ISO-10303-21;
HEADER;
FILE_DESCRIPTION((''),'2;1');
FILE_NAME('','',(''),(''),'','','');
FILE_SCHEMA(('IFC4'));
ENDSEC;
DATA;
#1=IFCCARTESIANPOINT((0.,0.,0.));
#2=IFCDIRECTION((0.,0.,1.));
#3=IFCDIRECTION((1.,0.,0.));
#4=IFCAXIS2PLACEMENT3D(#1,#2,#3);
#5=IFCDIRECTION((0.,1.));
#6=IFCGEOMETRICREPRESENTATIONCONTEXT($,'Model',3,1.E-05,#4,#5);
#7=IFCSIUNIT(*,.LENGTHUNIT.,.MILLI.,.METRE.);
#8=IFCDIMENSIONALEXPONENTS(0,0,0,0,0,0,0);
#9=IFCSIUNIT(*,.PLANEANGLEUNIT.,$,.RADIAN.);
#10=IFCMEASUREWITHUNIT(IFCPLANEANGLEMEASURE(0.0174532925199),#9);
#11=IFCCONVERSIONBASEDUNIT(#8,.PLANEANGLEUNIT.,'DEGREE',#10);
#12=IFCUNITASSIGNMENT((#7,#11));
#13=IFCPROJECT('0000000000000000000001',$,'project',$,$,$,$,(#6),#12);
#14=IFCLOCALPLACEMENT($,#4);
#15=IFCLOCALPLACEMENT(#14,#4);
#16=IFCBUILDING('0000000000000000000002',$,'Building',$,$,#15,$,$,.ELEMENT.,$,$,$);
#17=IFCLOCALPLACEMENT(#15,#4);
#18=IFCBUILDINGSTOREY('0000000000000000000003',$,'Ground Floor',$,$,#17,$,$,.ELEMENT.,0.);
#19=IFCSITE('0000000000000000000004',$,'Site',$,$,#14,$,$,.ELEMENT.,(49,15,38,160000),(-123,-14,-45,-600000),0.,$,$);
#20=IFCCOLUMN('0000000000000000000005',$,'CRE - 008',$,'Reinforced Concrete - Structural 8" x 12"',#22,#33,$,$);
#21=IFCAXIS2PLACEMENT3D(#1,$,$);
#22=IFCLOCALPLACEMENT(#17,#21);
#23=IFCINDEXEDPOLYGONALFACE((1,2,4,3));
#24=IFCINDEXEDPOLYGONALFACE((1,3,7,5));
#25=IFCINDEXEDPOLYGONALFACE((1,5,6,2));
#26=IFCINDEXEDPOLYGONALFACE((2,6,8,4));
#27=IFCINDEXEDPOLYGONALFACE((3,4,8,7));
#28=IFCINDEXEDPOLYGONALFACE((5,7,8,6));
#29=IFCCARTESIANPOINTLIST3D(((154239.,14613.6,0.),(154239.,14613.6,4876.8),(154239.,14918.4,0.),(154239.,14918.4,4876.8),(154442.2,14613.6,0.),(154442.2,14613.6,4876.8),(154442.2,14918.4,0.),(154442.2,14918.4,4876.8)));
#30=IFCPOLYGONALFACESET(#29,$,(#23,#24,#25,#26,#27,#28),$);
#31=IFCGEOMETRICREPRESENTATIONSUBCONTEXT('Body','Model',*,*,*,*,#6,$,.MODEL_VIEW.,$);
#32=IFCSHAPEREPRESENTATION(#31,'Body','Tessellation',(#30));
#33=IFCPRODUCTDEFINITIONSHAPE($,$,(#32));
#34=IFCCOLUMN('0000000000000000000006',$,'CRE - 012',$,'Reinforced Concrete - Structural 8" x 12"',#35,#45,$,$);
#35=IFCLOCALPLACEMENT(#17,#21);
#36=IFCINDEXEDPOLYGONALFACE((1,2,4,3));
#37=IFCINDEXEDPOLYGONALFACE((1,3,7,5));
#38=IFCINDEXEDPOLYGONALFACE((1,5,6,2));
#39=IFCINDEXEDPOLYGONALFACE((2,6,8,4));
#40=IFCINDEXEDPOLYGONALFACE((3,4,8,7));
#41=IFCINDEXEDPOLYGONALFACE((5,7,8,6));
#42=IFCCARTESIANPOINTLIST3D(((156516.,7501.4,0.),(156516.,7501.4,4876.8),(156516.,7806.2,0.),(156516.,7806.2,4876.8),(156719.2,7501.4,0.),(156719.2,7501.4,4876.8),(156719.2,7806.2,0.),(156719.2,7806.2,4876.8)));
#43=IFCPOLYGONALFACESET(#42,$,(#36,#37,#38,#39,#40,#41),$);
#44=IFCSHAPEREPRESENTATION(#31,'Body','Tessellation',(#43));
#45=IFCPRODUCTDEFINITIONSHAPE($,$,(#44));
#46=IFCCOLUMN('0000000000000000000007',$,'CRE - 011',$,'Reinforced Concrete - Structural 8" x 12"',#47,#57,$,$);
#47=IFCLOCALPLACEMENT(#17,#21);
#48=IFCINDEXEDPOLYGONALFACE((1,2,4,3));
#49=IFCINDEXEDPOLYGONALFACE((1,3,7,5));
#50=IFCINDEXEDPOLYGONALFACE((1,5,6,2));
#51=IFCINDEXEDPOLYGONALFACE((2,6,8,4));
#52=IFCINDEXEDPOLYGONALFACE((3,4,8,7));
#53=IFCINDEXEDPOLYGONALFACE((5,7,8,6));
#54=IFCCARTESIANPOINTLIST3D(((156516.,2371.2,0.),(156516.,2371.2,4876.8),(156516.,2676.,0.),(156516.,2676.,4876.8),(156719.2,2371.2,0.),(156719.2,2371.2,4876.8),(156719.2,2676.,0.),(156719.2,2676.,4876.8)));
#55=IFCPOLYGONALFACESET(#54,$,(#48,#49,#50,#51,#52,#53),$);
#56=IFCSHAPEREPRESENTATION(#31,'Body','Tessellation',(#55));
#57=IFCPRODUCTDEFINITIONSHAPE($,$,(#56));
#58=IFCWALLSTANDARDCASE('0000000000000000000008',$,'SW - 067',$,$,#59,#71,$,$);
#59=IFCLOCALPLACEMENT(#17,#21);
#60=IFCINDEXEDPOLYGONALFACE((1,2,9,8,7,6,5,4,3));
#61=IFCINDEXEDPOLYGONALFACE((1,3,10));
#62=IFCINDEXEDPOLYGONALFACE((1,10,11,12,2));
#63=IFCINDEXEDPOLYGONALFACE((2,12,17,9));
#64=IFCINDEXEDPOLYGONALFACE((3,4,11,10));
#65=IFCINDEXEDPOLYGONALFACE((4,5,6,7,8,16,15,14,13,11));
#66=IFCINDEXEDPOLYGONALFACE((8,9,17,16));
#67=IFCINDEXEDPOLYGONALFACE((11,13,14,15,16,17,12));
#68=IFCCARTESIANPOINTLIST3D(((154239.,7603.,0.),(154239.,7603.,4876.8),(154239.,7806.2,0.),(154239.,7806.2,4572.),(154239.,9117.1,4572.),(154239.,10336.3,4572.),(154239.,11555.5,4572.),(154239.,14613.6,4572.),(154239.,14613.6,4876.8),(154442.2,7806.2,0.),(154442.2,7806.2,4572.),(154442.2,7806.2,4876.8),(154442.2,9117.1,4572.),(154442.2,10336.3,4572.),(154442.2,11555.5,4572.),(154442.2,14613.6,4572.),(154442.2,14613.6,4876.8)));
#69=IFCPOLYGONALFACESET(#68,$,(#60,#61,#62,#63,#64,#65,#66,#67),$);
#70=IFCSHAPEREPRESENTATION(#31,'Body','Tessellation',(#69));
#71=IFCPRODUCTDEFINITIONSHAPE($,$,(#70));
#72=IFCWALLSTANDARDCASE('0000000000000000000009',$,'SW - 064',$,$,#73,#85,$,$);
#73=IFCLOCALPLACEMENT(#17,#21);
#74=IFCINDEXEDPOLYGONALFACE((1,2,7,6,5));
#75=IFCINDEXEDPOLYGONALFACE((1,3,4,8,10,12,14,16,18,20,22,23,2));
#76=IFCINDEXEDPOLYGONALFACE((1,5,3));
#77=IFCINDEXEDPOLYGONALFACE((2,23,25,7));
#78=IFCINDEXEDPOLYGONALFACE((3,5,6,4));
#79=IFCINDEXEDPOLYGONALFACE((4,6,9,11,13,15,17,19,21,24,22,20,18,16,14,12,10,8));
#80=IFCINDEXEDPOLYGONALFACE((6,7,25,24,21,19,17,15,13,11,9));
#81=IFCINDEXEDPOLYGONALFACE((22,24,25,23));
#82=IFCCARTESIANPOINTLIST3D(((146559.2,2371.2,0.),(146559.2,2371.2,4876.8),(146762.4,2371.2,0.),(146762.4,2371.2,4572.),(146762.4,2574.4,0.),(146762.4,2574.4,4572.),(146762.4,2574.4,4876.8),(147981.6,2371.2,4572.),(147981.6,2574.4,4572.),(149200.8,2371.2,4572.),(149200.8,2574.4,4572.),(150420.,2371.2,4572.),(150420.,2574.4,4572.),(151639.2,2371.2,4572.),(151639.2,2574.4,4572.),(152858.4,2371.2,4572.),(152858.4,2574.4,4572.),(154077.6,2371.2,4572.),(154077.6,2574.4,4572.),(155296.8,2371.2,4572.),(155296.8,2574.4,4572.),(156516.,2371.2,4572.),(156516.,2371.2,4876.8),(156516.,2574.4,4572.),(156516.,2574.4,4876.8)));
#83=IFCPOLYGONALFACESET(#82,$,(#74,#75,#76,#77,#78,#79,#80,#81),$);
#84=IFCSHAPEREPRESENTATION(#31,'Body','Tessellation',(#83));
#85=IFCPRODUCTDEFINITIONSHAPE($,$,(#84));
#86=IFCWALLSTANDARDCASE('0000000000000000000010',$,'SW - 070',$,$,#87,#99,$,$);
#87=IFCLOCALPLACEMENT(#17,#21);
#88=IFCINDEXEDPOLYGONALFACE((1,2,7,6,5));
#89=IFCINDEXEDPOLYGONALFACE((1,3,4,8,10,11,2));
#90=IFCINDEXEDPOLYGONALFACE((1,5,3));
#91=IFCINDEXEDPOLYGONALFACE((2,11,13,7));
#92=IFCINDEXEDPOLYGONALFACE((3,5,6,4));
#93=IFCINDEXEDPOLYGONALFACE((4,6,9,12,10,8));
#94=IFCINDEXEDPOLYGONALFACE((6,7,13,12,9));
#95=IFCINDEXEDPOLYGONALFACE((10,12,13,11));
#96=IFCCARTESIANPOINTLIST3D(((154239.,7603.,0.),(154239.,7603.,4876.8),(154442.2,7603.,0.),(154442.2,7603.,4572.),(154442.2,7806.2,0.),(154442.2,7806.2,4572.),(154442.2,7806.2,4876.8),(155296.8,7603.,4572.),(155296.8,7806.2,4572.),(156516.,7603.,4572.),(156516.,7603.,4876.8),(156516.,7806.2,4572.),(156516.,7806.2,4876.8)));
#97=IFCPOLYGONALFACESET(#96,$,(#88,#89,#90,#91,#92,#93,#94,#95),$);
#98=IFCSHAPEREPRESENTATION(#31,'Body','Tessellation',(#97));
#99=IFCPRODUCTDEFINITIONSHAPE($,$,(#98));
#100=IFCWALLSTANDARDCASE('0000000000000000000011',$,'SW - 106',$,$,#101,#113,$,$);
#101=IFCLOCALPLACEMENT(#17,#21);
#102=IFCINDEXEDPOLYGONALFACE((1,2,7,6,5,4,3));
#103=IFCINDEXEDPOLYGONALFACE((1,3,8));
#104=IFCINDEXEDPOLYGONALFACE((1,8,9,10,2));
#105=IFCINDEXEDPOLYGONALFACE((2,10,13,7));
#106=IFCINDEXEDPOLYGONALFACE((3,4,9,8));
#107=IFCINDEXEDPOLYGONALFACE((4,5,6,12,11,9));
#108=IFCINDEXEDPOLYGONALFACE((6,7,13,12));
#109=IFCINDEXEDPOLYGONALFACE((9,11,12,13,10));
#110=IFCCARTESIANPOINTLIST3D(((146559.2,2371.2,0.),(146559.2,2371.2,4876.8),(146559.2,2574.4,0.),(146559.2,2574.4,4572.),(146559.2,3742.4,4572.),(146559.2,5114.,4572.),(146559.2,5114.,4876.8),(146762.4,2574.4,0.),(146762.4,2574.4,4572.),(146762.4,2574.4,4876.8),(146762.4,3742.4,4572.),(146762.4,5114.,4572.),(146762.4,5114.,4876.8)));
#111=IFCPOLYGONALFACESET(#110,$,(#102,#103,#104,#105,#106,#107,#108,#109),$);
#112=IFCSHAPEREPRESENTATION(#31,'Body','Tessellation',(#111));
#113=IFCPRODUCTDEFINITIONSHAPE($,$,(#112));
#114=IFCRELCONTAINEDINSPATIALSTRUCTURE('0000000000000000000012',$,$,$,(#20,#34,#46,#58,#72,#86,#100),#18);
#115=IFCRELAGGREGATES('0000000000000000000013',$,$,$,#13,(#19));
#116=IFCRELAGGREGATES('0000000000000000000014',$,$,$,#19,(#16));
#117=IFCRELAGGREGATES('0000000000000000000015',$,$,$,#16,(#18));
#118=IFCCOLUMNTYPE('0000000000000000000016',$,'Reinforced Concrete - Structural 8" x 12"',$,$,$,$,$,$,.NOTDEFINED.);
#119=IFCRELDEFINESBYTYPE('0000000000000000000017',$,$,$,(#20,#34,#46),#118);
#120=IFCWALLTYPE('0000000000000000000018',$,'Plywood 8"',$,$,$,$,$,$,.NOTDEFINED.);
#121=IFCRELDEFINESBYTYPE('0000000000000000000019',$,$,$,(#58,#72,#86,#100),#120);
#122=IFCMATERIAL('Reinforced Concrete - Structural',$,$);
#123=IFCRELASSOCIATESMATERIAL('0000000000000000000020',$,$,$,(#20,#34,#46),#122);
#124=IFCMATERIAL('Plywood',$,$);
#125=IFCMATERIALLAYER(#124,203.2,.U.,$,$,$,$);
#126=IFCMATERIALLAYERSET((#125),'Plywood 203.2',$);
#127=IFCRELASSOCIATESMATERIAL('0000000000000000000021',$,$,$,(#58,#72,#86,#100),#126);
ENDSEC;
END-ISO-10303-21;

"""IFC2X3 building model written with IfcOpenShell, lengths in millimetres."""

from ifc_helpers import new_model, entity, si_unit, converted_unit, direction, frame, origin_with_axes, origin_2d_with_axis, place, context, subcontext, project, spatial, polyline, rectangle, outline, extrude, material, layer, layer_set, layer_usage, type_object, element, save


model = new_model("IFC2X3")

# Units and contexts
model_context = context("Model", 3, precision=1e-05, world=origin_with_axes(), true_north=direction((0.0, 1.0)))
body_context = subcontext(model_context, "Body", "Model", "MODEL_VIEW")
ifc_project = project(units=[si_unit("LENGTHUNIT", "METRE", prefix="MILLI"), converted_unit("PLANEANGLEUNIT", "DEGREE", entity("IfcPlaneAngleMeasure", 0.0174532925199), si_unit("PLANEANGLEUNIT", "RADIAN"), dimensions=[0, 0, 0, 0, 0, 0, 0])], contexts=[model_context])

# Site, building, storey
site_placement = place(None, origin_with_axes())
site = spatial("IfcSite", under=ifc_project, at=site_placement, Name="Site", CompositionType="ELEMENT", RefLatitude=(49, 15, 38, 160000), RefLongitude=(-123, -14, -45, -600000), RefElevation=0.0)
building_placement = place(site_placement, origin_with_axes())
building = spatial("IfcBuilding", under=site, at=building_placement, Name="Building", CompositionType="ELEMENT")
storey_placement = place(building_placement, origin_with_axes())
storey = spatial("IfcBuildingStorey", under=building, at=storey_placement, Name="Ground Floor", CompositionType="ELEMENT", Elevation=0.0)

# Columns
ifc_material_1 = material(Name="Reinforced Concrete - Structural")
column_type = type_object("IfcColumnType", Name="Reinforced Concrete - Structural 8\" x 12\"", PredefinedType="NOTDEFINED")
for number, where, z_axis, x_axis, name in (
    (1, (154340.6, 14766.0, 0.0), (0.0, 0.0, 1.0), (1.0, 0.0, 0.0), "CRE - 008"),
    (2, (156617.6, 7653.8, 0.0), (0.0, 0.0, 1.0), (1.0, 0.0, 0.0), "CRE - 012"),
    (3, (156617.6, 2523.6, 0.0), (0.0, 0.0, 1.0), (1.0, 0.0, 0.0), "CRE - 011"),
):
    element("IfcColumn", number, at=place(storey_placement, frame(where, z_axis=z_axis, x_axis=x_axis)), inside=storey, type_object=column_type, material=ifc_material_1, Name=name, ObjectType="Reinforced Concrete - Structural 8\" x 12\"", context=body_context, shape_type="SweptSolid", body=[
        extrude(rectangle(XDim=203.2, YDim=304.8, at=origin_2d_with_axis()), origin_with_axes(), (0.0, 0.0, 1.0), 4876.8),
    ])

# Walls, openings
ifc_material_2 = material(Name="Plywood")
ifc_layer = layer(ifc_material_2, 203.2, ventilated="UNKNOWN")
ifc_layer_set = layer_set([ifc_layer], Name="Plywood 203.2")
ifc_layer_usage_1 = layer_usage(ifc_layer_set, "AXIS2", "NEGATIVE", 0.0)
wall_type = type_object("IfcWallType", Name="Plywood 8\"", PredefinedType="NOTDEFINED")
wall_1_placement = place(storey_placement, frame((154239.0, 7603.0, 0.0), z_axis=(0.0, 0.0, 1.0), x_axis=(0.0, 1.0, 0.0)))
wall_1 = element("IfcWallStandardCase", 4, at=wall_1_placement, inside=storey, type_object=wall_type, material=ifc_layer_usage_1, Name="SW - 067", context=body_context, shape_type="SweptSolid", body=[
    extrude(outline(polyline([(203.2, -203.2), (7010.6, -203.2), (7010.6, 0.0), (0.0, 0.0), (203.2, -203.2)])), origin_with_axes(), (0.0, 0.0, 1.0), 4876.8),
])
opening_1_placement = place(wall_1_placement, frame((2123.6, 0.0, 0.0), z_axis=(0.0, 0.0, 1.0), x_axis=(1.0, 0.0, 0.0)))
element("IfcOpeningElement", 5, at=opening_1_placement, cuts=wall_1, context=body_context, shape_type="SweptSolid", body=[
    extrude(rectangle(XDim=1219.2, YDim=4572.0, at=origin_2d_with_axis()), frame((0.0, 203.2, 2286.0), z_axis=(0.0, -1.0, 0.0), x_axis=(-1.0, 0.0, 0.0)), (0.0, 0.0, 1.0), 609.6),
])
opening_2_placement = place(wall_1_placement, frame((858.6, 0.0, 0.0), z_axis=(0.0, 0.0, 1.0), x_axis=(1.0, 0.0, 0.0)))
element("IfcOpeningElement", 6, at=opening_2_placement, cuts=wall_1, context=body_context, shape_type="SweptSolid", body=[
    extrude(rectangle(XDim=1310.8, YDim=4572.0, at=origin_2d_with_axis()), frame((0.0, 203.2, 2286.0), z_axis=(0.0, 1.0, 0.0), x_axis=(1.0, 0.0, 0.0)), (0.0, 0.0, -1.0), 609.6),
])
opening_3_placement = place(wall_1_placement, frame((3342.8, 0.0, 0.0), z_axis=(0.0, 0.0, 1.0), x_axis=(1.0, 0.0, 0.0)))
element("IfcOpeningElement", 7, at=opening_3_placement, cuts=wall_1, context=body_context, shape_type="SweptSolid", body=[
    extrude(rectangle(XDim=1219.2, YDim=4572.0, at=origin_2d_with_axis()), frame((0.0, 203.2, 2286.0), z_axis=(0.0, -1.0, 0.0), x_axis=(-1.0, 0.0, 0.0)), (0.0, 0.0, 1.0), 609.6),
])
opening_4_placement = place(wall_1_placement, frame((5481.5, 0.0, 0.0), z_axis=(0.0, 0.0, 1.0), x_axis=(1.0, 0.0, 0.0)))
element("IfcOpeningElement", 8, at=opening_4_placement, cuts=wall_1, context=body_context, shape_type="SweptSolid", body=[
    extrude(rectangle(XDim=3058.2, YDim=4572.0, at=origin_2d_with_axis()), frame((0.0, 203.2, 2286.0), z_axis=(0.0, -1.0, 0.0), x_axis=(-1.0, 0.0, 0.0)), (0.0, 0.0, 1.0), 609.6),
])
ifc_layer_usage_2 = layer_usage(ifc_layer_set, "AXIS2", "POSITIVE", 0.0)
wall_2_placement = place(storey_placement, frame((156516.0, 2574.4, 0.0), z_axis=(0.0, 0.0, 1.0), x_axis=(-1.0, 0.0, 0.0)))
wall_2 = element("IfcWallStandardCase", 9, at=wall_2_placement, inside=storey, type_object=wall_type, material=ifc_layer_usage_2, Name="SW - 064", context=body_context, shape_type="SweptSolid", body=[
    extrude(outline(polyline([(0.0, 0.0), (9753.6, 0.0), (9956.8, 203.2), (0.0, 203.2), (0.0, 0.0)])), origin_with_axes(), (0.0, 0.0, 1.0), 4876.8),
])
opening_5_placement = place(wall_2_placement, frame((609.6, 0.0, 0.0), z_axis=(0.0, 0.0, 1.0), x_axis=(1.0, 0.0, 0.0)))
element("IfcOpeningElement", 10, at=opening_5_placement, cuts=wall_2, context=body_context, shape_type="SweptSolid", body=[
    extrude(rectangle(XDim=1219.2, YDim=4572.0, at=origin_2d_with_axis()), frame((0.0, -203.2, 2286.0), z_axis=(0.0, -1.0, 0.0), x_axis=(-1.0, 0.0, 0.0)), (0.0, 0.0, -1.0), 609.6),
])
opening_6_placement = place(wall_2_placement, frame((1828.8, 0.0, 0.0), z_axis=(0.0, 0.0, 1.0), x_axis=(1.0, 0.0, 0.0)))
element("IfcOpeningElement", 11, at=opening_6_placement, cuts=wall_2, context=body_context, shape_type="SweptSolid", body=[
    extrude(rectangle(XDim=1219.2, YDim=4572.0, at=origin_2d_with_axis()), frame((0.0, -203.2, 2286.0), z_axis=(0.0, -1.0, 0.0), x_axis=(-1.0, 0.0, 0.0)), (0.0, 0.0, -1.0), 609.6),
])
opening_7_placement = place(wall_2_placement, frame((3048.0, 0.0, 0.0), z_axis=(0.0, 0.0, 1.0), x_axis=(1.0, 0.0, 0.0)))
element("IfcOpeningElement", 12, at=opening_7_placement, cuts=wall_2, context=body_context, shape_type="SweptSolid", body=[
    extrude(rectangle(XDim=1219.2, YDim=4572.0, at=origin_2d_with_axis()), frame((0.0, -203.2, 2286.0), z_axis=(0.0, 1.0, 0.0), x_axis=(1.0, 0.0, 0.0)), (0.0, 0.0, 1.0), 609.6),
])
opening_8_placement = place(wall_2_placement, frame((4267.2, 0.0, 0.0), z_axis=(0.0, 0.0, 1.0), x_axis=(1.0, 0.0, 0.0)))
element("IfcOpeningElement", 13, at=opening_8_placement, cuts=wall_2, context=body_context, shape_type="SweptSolid", body=[
    extrude(rectangle(XDim=1219.2, YDim=4572.0, at=origin_2d_with_axis()), frame((0.0, -203.2, 2286.0), z_axis=(0.0, 1.0, 0.0), x_axis=(1.0, 0.0, 0.0)), (0.0, 0.0, 1.0), 609.6),
])
opening_9_placement = place(wall_2_placement, frame((5486.4, 0.0, 0.0), z_axis=(0.0, 0.0, 1.0), x_axis=(1.0, 0.0, 0.0)))
element("IfcOpeningElement", 14, at=opening_9_placement, cuts=wall_2, context=body_context, shape_type="SweptSolid", body=[
    extrude(rectangle(XDim=1219.2, YDim=4572.0, at=origin_2d_with_axis()), frame((0.0, -203.2, 2286.0), z_axis=(0.0, -1.0, 0.0), x_axis=(-1.0, 0.0, 0.0)), (0.0, 0.0, -1.0), 609.6),
])
opening_10_placement = place(wall_2_placement, frame((6705.6, 0.0, 0.0), z_axis=(0.0, 0.0, 1.0), x_axis=(1.0, 0.0, 0.0)))
element("IfcOpeningElement", 15, at=opening_10_placement, cuts=wall_2, context=body_context, shape_type="SweptSolid", body=[
    extrude(rectangle(XDim=1219.2, YDim=4572.0, at=origin_2d_with_axis()), frame((0.0, -203.2, 2286.0), z_axis=(0.0, 1.0, 0.0), x_axis=(1.0, 0.0, 0.0)), (0.0, 0.0, 1.0), 609.6),
])
opening_11_placement = place(wall_2_placement, frame((7924.8, 0.0, 0.0), z_axis=(0.0, 0.0, 1.0), x_axis=(1.0, 0.0, 0.0)))
element("IfcOpeningElement", 16, at=opening_11_placement, cuts=wall_2, context=body_context, shape_type="SweptSolid", body=[
    extrude(rectangle(XDim=1219.2, YDim=4572.0, at=origin_2d_with_axis()), frame((0.0, -203.2, 2286.0), z_axis=(0.0, -1.0, 0.0), x_axis=(-1.0, 0.0, 0.0)), (0.0, 0.0, -1.0), 609.6),
])
opening_12_placement = place(wall_2_placement, frame((9144.0, 0.0, 0.0), z_axis=(0.0, 0.0, 1.0), x_axis=(1.0, 0.0, 0.0)))
element("IfcOpeningElement", 17, at=opening_12_placement, cuts=wall_2, context=body_context, shape_type="SweptSolid", body=[
    extrude(rectangle(XDim=1219.2, YDim=4572.0, at=origin_2d_with_axis()), frame((0.0, -203.2, 2286.0), z_axis=(0.0, 1.0, 0.0), x_axis=(1.0, 0.0, 0.0)), (0.0, 0.0, 1.0), 609.6),
])
ifc_layer_usage_3 = layer_usage(ifc_layer_set, "AXIS2", "POSITIVE", 0.0)
wall_3_placement = place(storey_placement, frame((154239.0, 7603.0, 0.0), z_axis=(0.0, 0.0, 1.0), x_axis=(1.0, 0.0, 0.0)))
wall_3 = element("IfcWallStandardCase", 18, at=wall_3_placement, inside=storey, type_object=wall_type, material=ifc_layer_usage_3, Name="SW - 070", context=body_context, shape_type="SweptSolid", body=[
    extrude(outline(polyline([(0.0, 0.0), (2277.0, 0.0), (2277.0, 203.2), (203.2, 203.2), (0.0, 0.0)])), origin_with_axes(), (0.0, 0.0, 1.0), 4876.8),
])
opening_13_placement = place(wall_3_placement, frame((630.5, 0.0, 0.0), z_axis=(0.0, 0.0, 1.0), x_axis=(1.0, 0.0, 0.0)))
element("IfcOpeningElement", 19, at=opening_13_placement, cuts=wall_3, context=body_context, shape_type="SweptSolid", body=[
    extrude(rectangle(XDim=854.6, YDim=4572.0, at=origin_2d_with_axis()), frame((0.0, -203.2, 2286.0), z_axis=(0.0, 1.0, 0.0), x_axis=(1.0, 0.0, 0.0)), (0.0, 0.0, 1.0), 609.6),
])
opening_14_placement = place(wall_3_placement, frame((1667.4, 0.0, 0.0), z_axis=(0.0, 0.0, 1.0), x_axis=(1.0, 0.0, 0.0)))
element("IfcOpeningElement", 20, at=opening_14_placement, cuts=wall_3, context=body_context, shape_type="SweptSolid", body=[
    extrude(rectangle(XDim=1219.2, YDim=4572.0, at=origin_2d_with_axis()), frame((0.0, -203.2, 2286.0), z_axis=(0.0, 1.0, 0.0), x_axis=(1.0, 0.0, 0.0)), (0.0, 0.0, 1.0), 609.6),
])
ifc_layer_usage_4 = layer_usage(ifc_layer_set, "AXIS2", "NEGATIVE", 0.0)
wall_4_placement = place(storey_placement, frame((146762.4, 5114.0, 0.0), z_axis=(0.0, 0.0, 1.0), x_axis=(0.0, -1.0, 0.0)))
wall_4 = element("IfcWallStandardCase", 21, at=wall_4_placement, inside=storey, type_object=wall_type, material=ifc_layer_usage_4, Name="SW - 106", context=body_context, shape_type="SweptSolid", body=[
    extrude(outline(polyline([(0.0, -203.2), (2742.9, -203.2), (2539.7, 0.0), (0.0, 0.0), (0.0, -203.2)])), origin_with_axes(), (0.0, 0.0, 1.0), 4876.8),
])
opening_15_placement = place(wall_4_placement, frame((1955.6, 0.0, 0.0), z_axis=(0.0, 0.0, 1.0), x_axis=(1.0, 0.0, 0.0)))
element("IfcOpeningElement", 22, at=opening_15_placement, cuts=wall_4, context=body_context, shape_type="SweptSolid", body=[
    extrude(rectangle(XDim=1168.1, YDim=4572.0, at=origin_2d_with_axis()), frame((0.0, 203.2, 2286.0), z_axis=(0.0, -1.0, 0.0), x_axis=(-1.0, 0.0, 0.0)), (0.0, 0.0, 1.0), 609.6),
])
opening_16_placement = place(wall_4_placement, frame((685.8, 0.0, 0.0), z_axis=(0.0, 0.0, 1.0), x_axis=(1.0, 0.0, 0.0)))
element("IfcOpeningElement", 23, at=opening_16_placement, cuts=wall_4, context=body_context, shape_type="SweptSolid", body=[
    extrude(rectangle(XDim=1371.6, YDim=4572.0, at=origin_2d_with_axis()), frame((0.0, 203.2, 2286.0), z_axis=(0.0, -1.0, 0.0), x_axis=(-1.0, 0.0, 0.0)), (0.0, 0.0, 1.0), 609.6),
])

save(model, "model.ifc")
